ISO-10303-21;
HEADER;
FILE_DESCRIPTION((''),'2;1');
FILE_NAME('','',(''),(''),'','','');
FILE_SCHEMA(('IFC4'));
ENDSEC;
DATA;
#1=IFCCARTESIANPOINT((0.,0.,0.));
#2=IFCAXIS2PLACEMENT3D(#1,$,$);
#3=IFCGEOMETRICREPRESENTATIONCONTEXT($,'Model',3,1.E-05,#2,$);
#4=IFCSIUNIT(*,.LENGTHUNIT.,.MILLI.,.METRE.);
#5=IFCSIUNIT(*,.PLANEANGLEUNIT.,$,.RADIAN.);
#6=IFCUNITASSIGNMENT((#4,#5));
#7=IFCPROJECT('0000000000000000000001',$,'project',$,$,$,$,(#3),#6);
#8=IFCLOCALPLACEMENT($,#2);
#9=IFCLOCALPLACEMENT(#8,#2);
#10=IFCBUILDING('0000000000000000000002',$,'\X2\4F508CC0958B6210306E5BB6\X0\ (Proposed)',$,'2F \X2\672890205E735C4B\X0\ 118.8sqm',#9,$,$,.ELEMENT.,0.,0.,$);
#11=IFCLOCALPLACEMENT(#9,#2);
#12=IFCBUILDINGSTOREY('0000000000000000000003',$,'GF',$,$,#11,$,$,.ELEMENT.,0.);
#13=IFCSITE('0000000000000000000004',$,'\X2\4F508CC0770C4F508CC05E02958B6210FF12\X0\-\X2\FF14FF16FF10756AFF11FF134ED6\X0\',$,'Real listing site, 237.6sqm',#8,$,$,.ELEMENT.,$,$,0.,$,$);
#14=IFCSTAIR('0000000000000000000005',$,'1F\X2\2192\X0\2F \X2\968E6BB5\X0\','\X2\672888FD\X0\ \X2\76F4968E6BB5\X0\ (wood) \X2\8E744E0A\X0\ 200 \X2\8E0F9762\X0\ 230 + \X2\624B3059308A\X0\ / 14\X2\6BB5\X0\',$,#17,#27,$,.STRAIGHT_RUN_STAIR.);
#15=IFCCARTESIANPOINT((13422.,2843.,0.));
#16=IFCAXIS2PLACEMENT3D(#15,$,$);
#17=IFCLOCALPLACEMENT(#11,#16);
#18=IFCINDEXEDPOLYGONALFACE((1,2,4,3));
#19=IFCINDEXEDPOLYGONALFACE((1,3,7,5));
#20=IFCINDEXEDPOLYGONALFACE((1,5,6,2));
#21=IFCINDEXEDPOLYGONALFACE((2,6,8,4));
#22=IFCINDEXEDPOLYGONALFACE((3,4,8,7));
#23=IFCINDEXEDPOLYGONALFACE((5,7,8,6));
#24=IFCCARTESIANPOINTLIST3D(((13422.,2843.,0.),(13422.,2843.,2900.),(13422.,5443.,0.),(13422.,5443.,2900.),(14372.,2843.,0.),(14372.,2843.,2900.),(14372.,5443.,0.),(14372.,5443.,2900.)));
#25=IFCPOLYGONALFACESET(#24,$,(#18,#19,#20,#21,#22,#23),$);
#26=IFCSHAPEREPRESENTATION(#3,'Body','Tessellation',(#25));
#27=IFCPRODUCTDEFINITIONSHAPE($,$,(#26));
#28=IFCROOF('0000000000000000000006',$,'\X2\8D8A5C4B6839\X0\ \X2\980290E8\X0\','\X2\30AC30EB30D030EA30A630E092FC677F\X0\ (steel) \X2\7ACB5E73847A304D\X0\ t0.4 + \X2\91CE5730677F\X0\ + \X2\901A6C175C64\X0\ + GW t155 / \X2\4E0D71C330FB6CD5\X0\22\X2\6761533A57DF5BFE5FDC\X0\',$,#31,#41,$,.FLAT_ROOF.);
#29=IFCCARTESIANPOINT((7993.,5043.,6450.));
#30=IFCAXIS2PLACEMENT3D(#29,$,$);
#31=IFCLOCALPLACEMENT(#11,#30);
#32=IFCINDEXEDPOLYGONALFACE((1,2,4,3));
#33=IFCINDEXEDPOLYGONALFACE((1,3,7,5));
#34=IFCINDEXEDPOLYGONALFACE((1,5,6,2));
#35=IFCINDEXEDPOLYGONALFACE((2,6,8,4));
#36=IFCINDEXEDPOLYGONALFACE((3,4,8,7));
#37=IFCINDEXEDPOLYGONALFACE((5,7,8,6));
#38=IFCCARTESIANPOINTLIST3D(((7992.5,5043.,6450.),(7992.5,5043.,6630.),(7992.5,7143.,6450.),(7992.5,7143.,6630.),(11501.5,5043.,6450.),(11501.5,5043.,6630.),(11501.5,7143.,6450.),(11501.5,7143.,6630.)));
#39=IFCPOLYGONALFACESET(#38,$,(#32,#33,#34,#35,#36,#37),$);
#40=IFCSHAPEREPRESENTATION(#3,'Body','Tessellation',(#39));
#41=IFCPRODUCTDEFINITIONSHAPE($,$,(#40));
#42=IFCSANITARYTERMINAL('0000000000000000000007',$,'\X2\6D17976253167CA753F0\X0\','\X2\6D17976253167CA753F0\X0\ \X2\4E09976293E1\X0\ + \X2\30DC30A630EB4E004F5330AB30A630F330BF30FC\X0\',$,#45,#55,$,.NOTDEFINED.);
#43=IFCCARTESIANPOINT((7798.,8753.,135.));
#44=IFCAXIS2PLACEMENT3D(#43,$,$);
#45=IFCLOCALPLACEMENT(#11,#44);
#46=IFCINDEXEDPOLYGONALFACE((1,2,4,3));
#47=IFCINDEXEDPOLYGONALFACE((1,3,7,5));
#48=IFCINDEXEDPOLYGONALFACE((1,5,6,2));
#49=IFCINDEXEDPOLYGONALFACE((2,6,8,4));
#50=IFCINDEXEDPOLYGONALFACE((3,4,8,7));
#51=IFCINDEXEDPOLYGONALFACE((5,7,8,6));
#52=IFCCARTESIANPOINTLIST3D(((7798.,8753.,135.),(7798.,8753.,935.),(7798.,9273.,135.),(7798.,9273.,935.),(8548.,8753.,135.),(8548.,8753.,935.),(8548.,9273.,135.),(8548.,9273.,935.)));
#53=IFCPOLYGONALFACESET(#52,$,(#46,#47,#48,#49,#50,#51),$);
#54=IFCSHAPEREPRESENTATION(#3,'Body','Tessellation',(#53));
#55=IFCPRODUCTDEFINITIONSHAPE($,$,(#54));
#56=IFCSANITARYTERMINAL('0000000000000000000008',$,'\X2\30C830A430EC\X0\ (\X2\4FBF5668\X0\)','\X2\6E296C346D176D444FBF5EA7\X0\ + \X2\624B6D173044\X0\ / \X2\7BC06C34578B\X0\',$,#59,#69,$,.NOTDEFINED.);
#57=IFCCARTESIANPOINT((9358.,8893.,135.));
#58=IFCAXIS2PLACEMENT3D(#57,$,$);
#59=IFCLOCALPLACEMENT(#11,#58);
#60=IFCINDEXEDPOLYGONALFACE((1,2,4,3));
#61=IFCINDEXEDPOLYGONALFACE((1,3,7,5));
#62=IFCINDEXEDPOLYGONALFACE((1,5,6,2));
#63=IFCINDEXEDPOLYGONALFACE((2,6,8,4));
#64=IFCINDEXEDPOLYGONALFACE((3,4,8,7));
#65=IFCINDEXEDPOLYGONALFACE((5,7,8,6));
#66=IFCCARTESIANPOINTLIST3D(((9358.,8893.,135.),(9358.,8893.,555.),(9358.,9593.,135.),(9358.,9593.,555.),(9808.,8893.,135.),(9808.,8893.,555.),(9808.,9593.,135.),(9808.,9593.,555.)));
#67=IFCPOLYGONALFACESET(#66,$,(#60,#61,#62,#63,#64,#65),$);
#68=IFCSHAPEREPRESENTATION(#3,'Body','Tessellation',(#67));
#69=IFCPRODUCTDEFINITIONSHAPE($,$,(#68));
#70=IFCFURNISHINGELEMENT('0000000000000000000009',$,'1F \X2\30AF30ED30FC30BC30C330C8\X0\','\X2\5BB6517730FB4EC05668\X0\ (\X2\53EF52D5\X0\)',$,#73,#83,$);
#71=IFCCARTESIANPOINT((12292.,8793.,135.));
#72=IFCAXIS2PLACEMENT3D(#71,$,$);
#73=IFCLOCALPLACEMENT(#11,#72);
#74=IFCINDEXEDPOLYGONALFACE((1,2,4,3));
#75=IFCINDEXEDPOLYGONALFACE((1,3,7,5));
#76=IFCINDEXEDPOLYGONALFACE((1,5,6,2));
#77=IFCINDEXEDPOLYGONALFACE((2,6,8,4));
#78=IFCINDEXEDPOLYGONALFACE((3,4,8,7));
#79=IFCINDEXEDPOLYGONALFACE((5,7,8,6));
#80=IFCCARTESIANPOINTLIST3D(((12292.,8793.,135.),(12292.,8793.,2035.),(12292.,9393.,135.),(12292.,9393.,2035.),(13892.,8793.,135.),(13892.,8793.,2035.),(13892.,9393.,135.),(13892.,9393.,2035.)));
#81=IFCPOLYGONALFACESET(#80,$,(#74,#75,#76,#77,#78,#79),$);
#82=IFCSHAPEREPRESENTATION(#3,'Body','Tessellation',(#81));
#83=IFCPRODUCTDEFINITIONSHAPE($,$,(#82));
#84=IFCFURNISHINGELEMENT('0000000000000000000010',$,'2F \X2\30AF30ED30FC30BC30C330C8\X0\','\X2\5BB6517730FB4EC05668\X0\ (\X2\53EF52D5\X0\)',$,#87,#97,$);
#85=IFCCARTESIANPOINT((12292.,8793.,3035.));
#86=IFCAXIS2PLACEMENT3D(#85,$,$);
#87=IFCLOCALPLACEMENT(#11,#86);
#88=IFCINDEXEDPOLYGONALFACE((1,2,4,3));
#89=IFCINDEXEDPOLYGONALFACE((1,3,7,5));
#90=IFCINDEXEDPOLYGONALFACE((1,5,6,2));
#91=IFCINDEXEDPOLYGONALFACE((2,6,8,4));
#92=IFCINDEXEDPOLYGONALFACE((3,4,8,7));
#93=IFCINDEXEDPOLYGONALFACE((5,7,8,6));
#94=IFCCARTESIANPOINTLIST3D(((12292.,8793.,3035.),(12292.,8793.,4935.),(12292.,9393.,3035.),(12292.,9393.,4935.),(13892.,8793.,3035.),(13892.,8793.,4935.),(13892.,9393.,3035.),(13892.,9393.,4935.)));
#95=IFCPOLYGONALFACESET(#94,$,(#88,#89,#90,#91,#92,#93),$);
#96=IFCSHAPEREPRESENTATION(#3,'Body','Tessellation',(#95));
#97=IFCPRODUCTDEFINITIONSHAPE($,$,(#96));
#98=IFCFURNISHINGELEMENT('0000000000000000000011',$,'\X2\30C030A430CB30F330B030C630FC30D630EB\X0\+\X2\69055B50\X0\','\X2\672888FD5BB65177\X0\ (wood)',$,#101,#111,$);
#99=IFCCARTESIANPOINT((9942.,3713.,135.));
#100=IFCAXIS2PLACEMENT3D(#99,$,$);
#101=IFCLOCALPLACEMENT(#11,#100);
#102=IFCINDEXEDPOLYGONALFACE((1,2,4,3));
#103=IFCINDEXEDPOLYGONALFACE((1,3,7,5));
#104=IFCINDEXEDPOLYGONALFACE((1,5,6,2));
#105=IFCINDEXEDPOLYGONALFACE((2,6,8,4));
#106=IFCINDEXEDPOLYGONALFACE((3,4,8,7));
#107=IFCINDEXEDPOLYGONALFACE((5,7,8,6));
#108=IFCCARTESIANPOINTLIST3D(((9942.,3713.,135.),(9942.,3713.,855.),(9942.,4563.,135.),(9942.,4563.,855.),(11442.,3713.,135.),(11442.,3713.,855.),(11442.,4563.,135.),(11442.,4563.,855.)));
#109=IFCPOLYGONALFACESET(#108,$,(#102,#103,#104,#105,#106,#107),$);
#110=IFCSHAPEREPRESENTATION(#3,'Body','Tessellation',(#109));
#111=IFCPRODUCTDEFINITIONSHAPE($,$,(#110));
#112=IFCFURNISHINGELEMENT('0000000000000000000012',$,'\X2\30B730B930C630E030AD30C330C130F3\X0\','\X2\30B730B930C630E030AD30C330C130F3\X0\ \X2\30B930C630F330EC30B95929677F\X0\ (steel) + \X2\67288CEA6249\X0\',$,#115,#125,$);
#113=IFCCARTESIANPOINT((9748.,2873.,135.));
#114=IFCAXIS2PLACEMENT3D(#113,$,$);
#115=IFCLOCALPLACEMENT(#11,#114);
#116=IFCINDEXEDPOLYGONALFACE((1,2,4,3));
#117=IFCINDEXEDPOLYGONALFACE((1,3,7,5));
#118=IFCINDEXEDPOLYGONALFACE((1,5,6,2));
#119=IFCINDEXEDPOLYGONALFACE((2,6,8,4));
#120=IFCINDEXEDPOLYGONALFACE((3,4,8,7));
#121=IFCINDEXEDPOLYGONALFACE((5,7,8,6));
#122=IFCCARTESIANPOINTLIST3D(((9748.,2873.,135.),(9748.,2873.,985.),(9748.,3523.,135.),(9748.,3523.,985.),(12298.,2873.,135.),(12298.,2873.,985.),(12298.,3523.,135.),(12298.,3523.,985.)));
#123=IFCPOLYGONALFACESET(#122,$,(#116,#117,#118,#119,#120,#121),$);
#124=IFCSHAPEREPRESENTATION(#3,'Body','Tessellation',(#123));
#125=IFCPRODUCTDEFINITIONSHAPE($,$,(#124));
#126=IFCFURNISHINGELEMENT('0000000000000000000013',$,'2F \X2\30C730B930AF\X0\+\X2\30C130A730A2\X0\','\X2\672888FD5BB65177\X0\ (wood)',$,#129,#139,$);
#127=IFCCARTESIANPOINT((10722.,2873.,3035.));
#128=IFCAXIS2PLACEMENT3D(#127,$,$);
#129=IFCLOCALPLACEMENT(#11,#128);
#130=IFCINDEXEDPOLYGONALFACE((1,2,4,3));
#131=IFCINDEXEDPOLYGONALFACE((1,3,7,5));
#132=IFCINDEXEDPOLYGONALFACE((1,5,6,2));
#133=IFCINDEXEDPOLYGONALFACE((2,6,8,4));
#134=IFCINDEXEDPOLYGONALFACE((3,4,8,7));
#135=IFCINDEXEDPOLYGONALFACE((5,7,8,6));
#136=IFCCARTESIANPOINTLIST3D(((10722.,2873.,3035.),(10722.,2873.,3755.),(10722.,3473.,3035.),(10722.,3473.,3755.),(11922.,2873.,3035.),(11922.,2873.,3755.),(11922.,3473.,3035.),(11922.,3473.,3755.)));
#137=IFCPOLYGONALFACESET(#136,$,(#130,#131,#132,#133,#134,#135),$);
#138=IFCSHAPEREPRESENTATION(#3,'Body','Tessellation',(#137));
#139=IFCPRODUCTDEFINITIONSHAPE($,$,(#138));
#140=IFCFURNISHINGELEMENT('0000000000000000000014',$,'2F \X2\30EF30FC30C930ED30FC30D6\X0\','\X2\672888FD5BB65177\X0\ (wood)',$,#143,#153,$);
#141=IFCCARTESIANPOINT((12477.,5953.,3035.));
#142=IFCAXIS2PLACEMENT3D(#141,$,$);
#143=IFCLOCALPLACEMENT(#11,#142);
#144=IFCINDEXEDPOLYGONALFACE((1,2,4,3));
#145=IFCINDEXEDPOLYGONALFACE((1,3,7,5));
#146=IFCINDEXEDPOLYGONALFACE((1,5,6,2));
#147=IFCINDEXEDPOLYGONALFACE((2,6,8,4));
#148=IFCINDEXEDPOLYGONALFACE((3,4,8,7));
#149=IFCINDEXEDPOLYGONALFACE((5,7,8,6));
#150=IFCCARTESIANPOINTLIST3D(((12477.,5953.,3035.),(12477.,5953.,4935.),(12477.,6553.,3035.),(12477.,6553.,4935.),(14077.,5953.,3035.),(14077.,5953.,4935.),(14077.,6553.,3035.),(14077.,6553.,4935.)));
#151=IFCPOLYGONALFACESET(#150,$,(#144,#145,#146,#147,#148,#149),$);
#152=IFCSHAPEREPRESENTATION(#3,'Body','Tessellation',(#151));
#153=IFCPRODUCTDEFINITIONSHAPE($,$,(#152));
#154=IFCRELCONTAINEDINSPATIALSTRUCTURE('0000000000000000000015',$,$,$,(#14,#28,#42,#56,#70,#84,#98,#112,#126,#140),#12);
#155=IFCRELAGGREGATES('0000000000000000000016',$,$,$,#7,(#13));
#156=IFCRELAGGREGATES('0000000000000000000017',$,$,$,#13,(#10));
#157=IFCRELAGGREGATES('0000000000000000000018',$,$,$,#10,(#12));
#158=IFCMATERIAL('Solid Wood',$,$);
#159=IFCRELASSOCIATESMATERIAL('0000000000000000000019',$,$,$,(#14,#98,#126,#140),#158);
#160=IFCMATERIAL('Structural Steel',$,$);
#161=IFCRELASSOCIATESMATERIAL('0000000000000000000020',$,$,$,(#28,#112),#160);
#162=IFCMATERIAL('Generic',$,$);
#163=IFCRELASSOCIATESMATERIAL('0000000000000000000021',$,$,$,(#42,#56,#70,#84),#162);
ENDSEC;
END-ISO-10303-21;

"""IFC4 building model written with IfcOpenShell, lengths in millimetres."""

from ifc_helpers import new_model, si_unit, frame, frame_2d, origin, place, context, project, spatial, rectangle, extrude, material, element, save


model = new_model("IFC4")

# Units and contexts
model_context = context("Model", 3, precision=1e-05, world=origin())
ifc_project = project(units=[si_unit("LENGTHUNIT", "METRE", prefix="MILLI"), si_unit("PLANEANGLEUNIT", "RADIAN")], contexts=[model_context])

# Site, building, storey
site_placement = place(None, origin())
site = spatial("IfcSite", under=ifc_project, at=site_placement, Name="佐賀県佐賀市開成２-４６０番１３他", ObjectType="Real listing site, 237.6sqm", CompositionType="ELEMENT", RefElevation=0.0)
building_placement = place(site_placement, origin())
building = spatial("IfcBuilding", under=site, at=building_placement, Name="佐賀開成の家 (Proposed)", ObjectType="2F 木造平屋 118.8sqm", CompositionType="ELEMENT", ElevationOfRefHeight=0.0, ElevationOfTerrain=0.0)
storey_placement = place(building_placement, origin())
storey = spatial("IfcBuildingStorey", under=building, at=storey_placement, Name="GF", CompositionType="ELEMENT", Elevation=0.0)

# Shared definitions
ifc_material_1 = material(Name="Solid Wood")

# Stair
stair_placement = place(storey_placement, frame((13422.0, 2843.0, 0.0)))
element("IfcStair", 1, at=stair_placement, inside=storey, material=ifc_material_1, Name="1F→2F 階段", Description="木製 直階段 (wood) 蹴上 200 踏面 230 + 手すり / 14段", PredefinedType="STRAIGHT_RUN_STAIR", context=model_context, shape_type="SweptSolid", body=[
    extrude(rectangle(XDim=950.0, YDim=2600.0, at=frame_2d((475.0, 1300.0))), frame((13422.0, 2843.0, 0.0)), (0.0, 0.0, 1.0), 2900.0),
])

# Roof
ifc_material_2 = material(Name="Structural Steel")
roof_placement = place(storey_placement, frame((7993.0, 5043.0, 6450.0)))
element("IfcRoof", 2, at=roof_placement, inside=storey, material=ifc_material_2, Name="越屋根 頂部", Description="ガルバリウム鋼板 (steel) 立平葺き t0.4 + 野地板 + 通気層 + GW t155 / 不燃・法22条区域対応", PredefinedType="FLAT_ROOF", context=model_context, shape_type="SweptSolid", body=[
    extrude(rectangle(XDim=3509.0, YDim=2100.0, at=frame_2d((1754.0, 1050.0))), frame((7993.0, 5043.0, 6450.0)), (0.0, 0.0, 1.0), 180.0),
])

# Sanitary terminals
ifc_material_3 = material(Name="Generic")
sanitary_terminal_1_placement = place(storey_placement, frame((7798.0, 8753.0, 135.0)))
element("IfcSanitaryTerminal", 3, at=sanitary_terminal_1_placement, inside=storey, material=ifc_material_3, Name="洗面化粧台", Description="洗面化粧台 三面鏡 + ボウル一体カウンター", PredefinedType="NOTDEFINED", context=model_context, shape_type="SweptSolid", body=[
    extrude(rectangle(XDim=750.0, YDim=520.0, at=frame_2d((375.0, 260.0))), frame((7798.0, 8753.0, 135.0)), (0.0, 0.0, 1.0), 800.0),
])
sanitary_terminal_2_placement = place(storey_placement, frame((9358.0, 8893.0, 135.0)))
element("IfcSanitaryTerminal", 4, at=sanitary_terminal_2_placement, inside=storey, material=ifc_material_3, Name="トイレ (便器)", Description="温水洗浄便座 + 手洗い / 節水型", PredefinedType="NOTDEFINED", context=model_context, shape_type="SweptSolid", body=[
    extrude(rectangle(XDim=450.0, YDim=700.0, at=frame_2d((225.0, 350.0))), frame((9358.0, 8893.0, 135.0)), (0.0, 0.0, 1.0), 420.0),
])

# Furnishing elements
furnishing_1_placement = place(storey_placement, frame((12292.0, 8793.0, 135.0)))
element("IfcFurnishingElement", 5, at=furnishing_1_placement, inside=storey, material=ifc_material_3, Name="1F クローゼット", Description="家具・什器 (可動)", context=model_context, shape_type="SweptSolid", body=[
    extrude(rectangle(XDim=1600.0, YDim=600.0, at=frame_2d((800.0, 300.0))), frame((12292.0, 8793.0, 135.0)), (0.0, 0.0, 1.0), 1900.0),
])
furnishing_2_placement = place(storey_placement, frame((12292.0, 8793.0, 3035.0)))
element("IfcFurnishingElement", 6, at=furnishing_2_placement, inside=storey, material=ifc_material_3, Name="2F クローゼット", Description="家具・什器 (可動)", context=model_context, shape_type="SweptSolid", body=[
    extrude(rectangle(XDim=1600.0, YDim=600.0, at=frame_2d((800.0, 300.0))), frame((12292.0, 8793.0, 3035.0)), (0.0, 0.0, 1.0), 1900.0),
])
furnishing_3_placement = place(storey_placement, frame((9942.0, 3713.0, 135.0)))
element("IfcFurnishingElement", 7, at=furnishing_3_placement, inside=storey, material=ifc_material_1, Name="ダイニングテーブル+椅子", Description="木製家具 (wood)", context=model_context, shape_type="SweptSolid", body=[
    extrude(rectangle(XDim=1500.0, YDim=850.0, at=frame_2d((750.0, 425.0))), frame((9942.0, 3713.0, 135.0)), (0.0, 0.0, 1.0), 720.0),
])
furnishing_4_placement = place(storey_placement, frame((9748.0, 2873.0, 135.0)))
element("IfcFurnishingElement", 8, at=furnishing_4_placement, inside=storey, material=ifc_material_2, Name="システムキッチン", Description="システムキッチン ステンレス天板 (steel) + 木質扉", context=model_context, shape_type="SweptSolid", body=[
    extrude(rectangle(XDim=2550.0, YDim=650.0, at=frame_2d((1275.0, 325.0))), frame((9748.0, 2873.0, 135.0)), (0.0, 0.0, 1.0), 850.0),
])
furnishing_5_placement = place(storey_placement, frame((10722.0, 2873.0, 3035.0)))
element("IfcFurnishingElement", 9, at=furnishing_5_placement, inside=storey, material=ifc_material_1, Name="2F デスク+チェア", Description="木製家具 (wood)", context=model_context, shape_type="SweptSolid", body=[
    extrude(rectangle(XDim=1200.0, YDim=600.0, at=frame_2d((600.0, 300.0))), frame((10722.0, 2873.0, 3035.0)), (0.0, 0.0, 1.0), 720.0),
])
furnishing_6_placement = place(storey_placement, frame((12477.0, 5953.0, 3035.0)))
element("IfcFurnishingElement", 10, at=furnishing_6_placement, inside=storey, material=ifc_material_1, Name="2F ワードローブ", Description="木製家具 (wood)", context=model_context, shape_type="SweptSolid", body=[
    extrude(rectangle(XDim=1600.0, YDim=600.0, at=frame_2d((800.0, 300.0))), frame((12477.0, 5953.0, 3035.0)), (0.0, 0.0, 1.0), 1900.0),
])

save(model, "model.ifc")
